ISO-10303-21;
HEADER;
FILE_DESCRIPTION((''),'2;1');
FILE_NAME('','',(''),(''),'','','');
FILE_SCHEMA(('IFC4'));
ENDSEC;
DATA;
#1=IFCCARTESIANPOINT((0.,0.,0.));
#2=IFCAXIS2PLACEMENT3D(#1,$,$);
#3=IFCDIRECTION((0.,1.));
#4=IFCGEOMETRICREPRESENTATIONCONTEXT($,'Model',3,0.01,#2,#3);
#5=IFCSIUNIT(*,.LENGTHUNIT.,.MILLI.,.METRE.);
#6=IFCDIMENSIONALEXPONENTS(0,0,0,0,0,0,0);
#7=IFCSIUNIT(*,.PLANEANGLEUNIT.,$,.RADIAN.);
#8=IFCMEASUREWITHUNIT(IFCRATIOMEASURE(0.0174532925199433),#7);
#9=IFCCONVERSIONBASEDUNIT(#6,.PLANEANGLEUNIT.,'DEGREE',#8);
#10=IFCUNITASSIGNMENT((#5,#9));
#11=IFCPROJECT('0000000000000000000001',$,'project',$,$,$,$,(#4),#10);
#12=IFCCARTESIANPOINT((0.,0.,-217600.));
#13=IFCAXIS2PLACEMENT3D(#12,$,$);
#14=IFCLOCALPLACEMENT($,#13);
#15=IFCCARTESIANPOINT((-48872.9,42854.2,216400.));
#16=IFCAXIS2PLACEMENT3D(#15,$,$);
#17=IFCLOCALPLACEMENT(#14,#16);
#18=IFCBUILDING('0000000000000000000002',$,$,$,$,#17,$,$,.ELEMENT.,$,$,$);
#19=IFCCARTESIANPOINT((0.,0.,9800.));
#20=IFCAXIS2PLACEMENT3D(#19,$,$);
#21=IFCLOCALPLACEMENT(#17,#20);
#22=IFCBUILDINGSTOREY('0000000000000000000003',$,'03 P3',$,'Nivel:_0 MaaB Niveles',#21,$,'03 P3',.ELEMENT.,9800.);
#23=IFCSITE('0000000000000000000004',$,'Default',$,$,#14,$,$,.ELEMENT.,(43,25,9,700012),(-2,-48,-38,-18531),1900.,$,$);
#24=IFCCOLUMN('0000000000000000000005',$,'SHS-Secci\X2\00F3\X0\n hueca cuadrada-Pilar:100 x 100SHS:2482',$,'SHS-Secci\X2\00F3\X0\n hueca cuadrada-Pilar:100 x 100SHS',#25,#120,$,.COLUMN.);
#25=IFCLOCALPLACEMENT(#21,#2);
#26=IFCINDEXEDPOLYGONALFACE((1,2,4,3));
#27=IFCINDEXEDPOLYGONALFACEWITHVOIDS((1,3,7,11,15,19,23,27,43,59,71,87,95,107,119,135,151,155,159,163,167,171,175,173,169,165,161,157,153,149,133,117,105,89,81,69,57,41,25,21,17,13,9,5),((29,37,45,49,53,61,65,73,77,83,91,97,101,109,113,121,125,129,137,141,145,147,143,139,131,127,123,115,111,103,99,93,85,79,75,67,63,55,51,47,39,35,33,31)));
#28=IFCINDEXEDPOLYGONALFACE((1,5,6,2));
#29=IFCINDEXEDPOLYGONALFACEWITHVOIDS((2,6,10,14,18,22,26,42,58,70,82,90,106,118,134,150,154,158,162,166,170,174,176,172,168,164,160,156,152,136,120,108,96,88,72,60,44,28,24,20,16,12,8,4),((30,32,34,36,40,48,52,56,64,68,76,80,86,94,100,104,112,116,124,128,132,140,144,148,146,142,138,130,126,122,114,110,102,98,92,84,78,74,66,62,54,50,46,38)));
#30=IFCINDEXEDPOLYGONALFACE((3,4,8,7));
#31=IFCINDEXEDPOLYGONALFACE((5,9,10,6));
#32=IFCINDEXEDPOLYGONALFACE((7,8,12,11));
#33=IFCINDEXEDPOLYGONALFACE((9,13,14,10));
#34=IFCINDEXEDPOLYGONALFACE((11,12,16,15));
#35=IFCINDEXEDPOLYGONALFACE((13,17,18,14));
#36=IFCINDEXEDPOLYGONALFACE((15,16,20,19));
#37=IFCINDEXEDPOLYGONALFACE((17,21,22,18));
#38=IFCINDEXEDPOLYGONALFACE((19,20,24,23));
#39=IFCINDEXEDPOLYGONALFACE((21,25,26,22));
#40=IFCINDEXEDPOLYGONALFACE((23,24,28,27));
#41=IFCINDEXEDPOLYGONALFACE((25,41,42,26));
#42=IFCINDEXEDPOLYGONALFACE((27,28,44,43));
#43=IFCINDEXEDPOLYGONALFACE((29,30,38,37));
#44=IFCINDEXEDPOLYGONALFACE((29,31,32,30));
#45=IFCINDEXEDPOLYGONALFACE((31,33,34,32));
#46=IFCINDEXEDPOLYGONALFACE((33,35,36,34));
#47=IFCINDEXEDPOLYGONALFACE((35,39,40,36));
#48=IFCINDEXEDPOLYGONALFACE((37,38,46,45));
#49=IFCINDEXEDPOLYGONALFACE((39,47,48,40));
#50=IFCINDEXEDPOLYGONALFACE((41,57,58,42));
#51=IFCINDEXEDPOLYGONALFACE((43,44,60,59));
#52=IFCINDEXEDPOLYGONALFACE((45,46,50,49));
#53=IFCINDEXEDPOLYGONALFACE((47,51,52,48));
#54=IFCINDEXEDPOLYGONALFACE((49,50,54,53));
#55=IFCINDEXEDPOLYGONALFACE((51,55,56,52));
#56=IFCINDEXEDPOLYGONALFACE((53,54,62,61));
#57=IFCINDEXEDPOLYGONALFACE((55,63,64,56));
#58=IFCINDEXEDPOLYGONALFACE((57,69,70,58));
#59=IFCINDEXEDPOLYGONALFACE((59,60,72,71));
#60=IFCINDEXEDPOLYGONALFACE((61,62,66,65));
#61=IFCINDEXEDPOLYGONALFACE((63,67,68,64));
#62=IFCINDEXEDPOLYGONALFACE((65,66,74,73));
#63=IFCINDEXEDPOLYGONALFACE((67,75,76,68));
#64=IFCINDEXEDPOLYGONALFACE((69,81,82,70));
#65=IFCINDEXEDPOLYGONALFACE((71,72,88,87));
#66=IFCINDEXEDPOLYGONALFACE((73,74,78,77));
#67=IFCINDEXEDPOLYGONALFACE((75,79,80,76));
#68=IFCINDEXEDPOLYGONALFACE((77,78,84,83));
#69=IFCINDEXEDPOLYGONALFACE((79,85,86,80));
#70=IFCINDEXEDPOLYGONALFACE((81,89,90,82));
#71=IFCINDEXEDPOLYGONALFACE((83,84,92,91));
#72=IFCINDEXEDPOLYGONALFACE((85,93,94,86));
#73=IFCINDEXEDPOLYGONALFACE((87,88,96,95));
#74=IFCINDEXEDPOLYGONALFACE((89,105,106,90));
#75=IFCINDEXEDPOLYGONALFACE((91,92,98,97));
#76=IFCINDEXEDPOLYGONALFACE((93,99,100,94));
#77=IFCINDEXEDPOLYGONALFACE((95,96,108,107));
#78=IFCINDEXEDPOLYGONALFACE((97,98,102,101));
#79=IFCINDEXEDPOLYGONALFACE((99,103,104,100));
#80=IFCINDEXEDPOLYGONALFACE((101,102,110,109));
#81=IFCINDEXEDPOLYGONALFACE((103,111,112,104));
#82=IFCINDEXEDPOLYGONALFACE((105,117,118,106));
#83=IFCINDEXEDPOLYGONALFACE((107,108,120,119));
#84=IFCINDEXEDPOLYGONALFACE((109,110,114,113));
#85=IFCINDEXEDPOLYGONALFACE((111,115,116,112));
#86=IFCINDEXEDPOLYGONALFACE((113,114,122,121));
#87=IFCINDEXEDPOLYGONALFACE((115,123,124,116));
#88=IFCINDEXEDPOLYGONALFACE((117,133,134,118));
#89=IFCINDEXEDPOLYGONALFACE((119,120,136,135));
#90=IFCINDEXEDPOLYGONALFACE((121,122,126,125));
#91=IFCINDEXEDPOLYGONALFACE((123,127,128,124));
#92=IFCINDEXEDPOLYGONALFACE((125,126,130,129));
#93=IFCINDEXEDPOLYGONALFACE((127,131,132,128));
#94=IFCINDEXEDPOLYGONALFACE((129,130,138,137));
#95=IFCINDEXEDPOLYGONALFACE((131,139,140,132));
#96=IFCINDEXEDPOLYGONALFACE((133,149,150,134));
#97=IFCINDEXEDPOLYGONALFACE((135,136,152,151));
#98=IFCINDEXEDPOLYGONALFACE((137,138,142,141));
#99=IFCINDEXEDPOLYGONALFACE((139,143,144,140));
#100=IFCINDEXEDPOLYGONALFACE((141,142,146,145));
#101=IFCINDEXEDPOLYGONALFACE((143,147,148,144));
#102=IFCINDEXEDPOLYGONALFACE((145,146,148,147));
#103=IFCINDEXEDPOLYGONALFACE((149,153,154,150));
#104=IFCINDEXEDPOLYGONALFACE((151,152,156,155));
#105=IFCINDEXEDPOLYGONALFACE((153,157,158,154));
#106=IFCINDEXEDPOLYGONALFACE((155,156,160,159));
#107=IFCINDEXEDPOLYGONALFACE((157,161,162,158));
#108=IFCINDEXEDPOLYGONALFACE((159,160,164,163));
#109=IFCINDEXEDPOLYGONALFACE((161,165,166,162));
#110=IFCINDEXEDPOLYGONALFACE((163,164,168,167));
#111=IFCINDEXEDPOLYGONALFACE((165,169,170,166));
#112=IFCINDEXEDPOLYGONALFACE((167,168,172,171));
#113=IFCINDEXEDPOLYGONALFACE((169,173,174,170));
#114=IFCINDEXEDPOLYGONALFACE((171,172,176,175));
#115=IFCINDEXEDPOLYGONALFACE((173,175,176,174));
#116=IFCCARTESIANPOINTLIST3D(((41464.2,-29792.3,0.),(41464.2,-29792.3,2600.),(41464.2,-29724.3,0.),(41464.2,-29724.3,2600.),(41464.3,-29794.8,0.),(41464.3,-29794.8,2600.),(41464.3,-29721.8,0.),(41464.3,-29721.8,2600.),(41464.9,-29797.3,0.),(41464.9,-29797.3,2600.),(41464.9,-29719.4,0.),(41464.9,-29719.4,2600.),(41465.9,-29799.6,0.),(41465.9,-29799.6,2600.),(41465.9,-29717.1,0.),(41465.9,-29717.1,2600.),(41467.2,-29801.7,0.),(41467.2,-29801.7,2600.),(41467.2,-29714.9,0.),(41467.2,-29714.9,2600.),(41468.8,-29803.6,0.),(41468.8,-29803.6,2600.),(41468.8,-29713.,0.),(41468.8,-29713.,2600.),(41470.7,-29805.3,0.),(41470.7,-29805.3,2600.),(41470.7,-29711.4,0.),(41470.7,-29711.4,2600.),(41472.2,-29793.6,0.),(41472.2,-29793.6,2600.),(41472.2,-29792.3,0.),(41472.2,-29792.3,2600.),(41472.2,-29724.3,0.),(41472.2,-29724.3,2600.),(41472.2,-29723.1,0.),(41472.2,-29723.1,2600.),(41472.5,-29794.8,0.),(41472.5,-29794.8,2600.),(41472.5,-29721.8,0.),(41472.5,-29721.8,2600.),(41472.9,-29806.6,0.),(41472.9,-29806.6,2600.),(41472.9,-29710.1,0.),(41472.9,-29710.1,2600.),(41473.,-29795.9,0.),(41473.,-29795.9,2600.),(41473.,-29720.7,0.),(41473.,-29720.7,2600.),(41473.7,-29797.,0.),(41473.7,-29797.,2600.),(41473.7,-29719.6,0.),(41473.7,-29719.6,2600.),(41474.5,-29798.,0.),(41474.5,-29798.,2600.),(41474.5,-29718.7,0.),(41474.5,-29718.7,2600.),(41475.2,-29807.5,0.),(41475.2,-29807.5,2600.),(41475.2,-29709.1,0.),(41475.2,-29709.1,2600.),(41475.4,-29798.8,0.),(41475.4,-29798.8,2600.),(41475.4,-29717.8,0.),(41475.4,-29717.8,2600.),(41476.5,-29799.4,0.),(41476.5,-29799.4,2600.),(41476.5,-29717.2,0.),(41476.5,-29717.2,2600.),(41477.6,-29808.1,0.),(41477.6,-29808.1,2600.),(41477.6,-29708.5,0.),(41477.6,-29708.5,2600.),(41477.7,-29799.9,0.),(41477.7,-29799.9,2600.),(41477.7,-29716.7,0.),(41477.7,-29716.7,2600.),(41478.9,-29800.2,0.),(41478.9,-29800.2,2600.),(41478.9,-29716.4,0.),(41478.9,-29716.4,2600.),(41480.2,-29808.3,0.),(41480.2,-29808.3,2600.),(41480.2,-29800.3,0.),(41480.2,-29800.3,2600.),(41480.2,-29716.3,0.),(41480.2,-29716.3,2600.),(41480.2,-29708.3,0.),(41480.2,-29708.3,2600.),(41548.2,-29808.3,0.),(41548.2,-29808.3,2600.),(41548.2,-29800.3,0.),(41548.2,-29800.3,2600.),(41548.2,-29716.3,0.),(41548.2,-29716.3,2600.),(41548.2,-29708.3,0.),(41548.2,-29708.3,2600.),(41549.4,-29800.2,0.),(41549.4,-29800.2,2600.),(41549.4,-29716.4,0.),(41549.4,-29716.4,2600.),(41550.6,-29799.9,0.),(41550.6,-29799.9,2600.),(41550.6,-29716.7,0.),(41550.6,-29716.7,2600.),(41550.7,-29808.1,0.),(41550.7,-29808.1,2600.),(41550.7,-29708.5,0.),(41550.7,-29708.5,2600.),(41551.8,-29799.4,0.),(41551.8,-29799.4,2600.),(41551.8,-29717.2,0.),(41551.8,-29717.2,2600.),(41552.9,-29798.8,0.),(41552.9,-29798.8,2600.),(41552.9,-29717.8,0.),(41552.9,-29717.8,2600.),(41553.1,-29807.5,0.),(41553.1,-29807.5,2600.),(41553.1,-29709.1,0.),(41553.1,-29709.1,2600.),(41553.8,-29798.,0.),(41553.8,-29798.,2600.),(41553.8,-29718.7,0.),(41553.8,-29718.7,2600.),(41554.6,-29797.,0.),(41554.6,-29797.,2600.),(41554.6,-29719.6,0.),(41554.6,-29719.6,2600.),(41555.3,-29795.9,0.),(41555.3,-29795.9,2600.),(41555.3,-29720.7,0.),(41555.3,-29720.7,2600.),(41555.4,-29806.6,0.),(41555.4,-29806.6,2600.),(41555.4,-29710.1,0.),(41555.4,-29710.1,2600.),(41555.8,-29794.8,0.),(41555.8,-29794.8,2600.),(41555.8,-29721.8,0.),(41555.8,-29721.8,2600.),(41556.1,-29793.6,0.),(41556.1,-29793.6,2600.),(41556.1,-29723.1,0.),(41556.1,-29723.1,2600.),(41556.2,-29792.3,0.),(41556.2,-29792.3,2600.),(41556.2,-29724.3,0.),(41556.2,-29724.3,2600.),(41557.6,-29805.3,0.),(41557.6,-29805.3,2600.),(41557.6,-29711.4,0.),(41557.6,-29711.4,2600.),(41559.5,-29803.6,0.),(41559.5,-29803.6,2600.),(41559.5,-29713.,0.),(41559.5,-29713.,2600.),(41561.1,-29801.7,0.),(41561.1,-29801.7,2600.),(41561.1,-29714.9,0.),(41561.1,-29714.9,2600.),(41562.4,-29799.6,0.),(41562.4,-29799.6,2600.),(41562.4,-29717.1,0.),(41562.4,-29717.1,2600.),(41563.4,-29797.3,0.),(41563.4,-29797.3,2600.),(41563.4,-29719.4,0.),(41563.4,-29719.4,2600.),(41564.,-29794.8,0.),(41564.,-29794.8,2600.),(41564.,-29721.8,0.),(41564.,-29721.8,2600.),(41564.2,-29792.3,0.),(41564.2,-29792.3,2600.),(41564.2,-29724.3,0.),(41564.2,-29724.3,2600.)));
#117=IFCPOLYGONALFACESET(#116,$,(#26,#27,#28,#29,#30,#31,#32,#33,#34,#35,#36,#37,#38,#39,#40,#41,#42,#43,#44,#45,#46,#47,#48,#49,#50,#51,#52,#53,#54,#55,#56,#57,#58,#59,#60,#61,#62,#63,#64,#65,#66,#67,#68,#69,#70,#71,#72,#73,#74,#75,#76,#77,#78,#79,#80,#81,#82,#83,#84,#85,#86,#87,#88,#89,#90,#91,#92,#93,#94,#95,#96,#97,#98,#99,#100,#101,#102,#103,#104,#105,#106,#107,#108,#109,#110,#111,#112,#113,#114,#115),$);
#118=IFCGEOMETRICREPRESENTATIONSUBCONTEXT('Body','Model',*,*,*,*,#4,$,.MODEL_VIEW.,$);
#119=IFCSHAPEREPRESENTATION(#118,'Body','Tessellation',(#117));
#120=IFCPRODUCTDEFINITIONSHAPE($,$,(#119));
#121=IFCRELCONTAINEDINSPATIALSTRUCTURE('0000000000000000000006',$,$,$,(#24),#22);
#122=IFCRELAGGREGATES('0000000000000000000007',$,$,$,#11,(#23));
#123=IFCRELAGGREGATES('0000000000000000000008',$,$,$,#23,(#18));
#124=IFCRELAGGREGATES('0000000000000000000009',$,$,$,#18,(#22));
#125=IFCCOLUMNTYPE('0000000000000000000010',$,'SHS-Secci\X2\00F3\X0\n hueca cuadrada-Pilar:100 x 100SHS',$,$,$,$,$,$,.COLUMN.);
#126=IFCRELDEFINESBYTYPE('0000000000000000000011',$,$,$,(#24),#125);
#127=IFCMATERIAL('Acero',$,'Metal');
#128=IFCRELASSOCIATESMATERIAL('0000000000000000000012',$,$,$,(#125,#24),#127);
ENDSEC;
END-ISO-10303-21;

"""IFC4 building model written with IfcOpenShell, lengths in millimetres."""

from ifc_helpers import new_model, entity, si_unit, converted_unit, direction, frame, origin, place, context, subcontext, project, spatial, indexed_curve, outline, extrude, source, transform, mapped, material, type_object, type_shapes, element, save


model = new_model("IFC4")

# Units and contexts
model_context = context("Model", 3, precision=0.01, world=origin(), true_north=direction((0.0, 1.0)))
body_context = subcontext(model_context, "Body", "Model", "MODEL_VIEW")
ifc_project = project(units=[si_unit("LENGTHUNIT", "METRE", prefix="MILLI"), converted_unit("PLANEANGLEUNIT", "DEGREE", entity("IfcRatioMeasure", 0.0174532925199433), si_unit("PLANEANGLEUNIT", "RADIAN"), dimensions=[0, 0, 0, 0, 0, 0, 0])], contexts=[model_context])

# Site, building, storey
site_placement = place(None, frame((0.0, 0.0, -217600.0)))
site = spatial("IfcSite", under=ifc_project, at=site_placement, Name="Default", CompositionType="ELEMENT", RefLatitude=(43, 25, 9, 700012), RefLongitude=(-2, -48, -38, -18531), RefElevation=1900.0)
building_placement = place(site_placement, frame((-48872.9, 42854.2, 216400.0)))
building = spatial("IfcBuilding", under=site, at=building_placement, CompositionType="ELEMENT")
storey_placement = place(building_placement, frame((0.0, 0.0, 9800.0)))
storey = spatial("IfcBuildingStorey", under=building, at=storey_placement, Name="03 P3", ObjectType="Nivel:_0 MaaB Niveles", LongName="03 P3", CompositionType="ELEMENT", Elevation=9800.0)

# Column
ifc_material_1 = material(Name="Acero", Category="Metal")
column_type_1 = type_object("IfcColumnType", Name="SHS-Sección hueca cuadrada-Pilar:100 x 100SHS", PredefinedType="COLUMN", material=ifc_material_1)
shared_shape_1 = source(origin(), body_context, "Body", "SweptSolid", [
    extrude(outline(indexed_curve([(-34.0, -50.0), (34.0, -50.0), (36.5, -49.8), (38.9, -49.2), (41.3, -48.3), (43.4, -46.9), (45.3, -45.3), (46.9, -43.4), (48.3, -41.3), (49.2, -38.9), (49.8, -36.5), (50.0, -34.0), (50.0, 34.0), (49.8, 36.5), (49.2, 38.9), (48.3, 41.3), (46.9, 43.4), (45.3, 45.3), (43.4, 46.9), (41.3, 48.3), (38.9, 49.2), (36.5, 49.8), (34.0, 50.0), (-34.0, 50.0), (-36.5, 49.8), (-38.9, 49.2), (-41.3, 48.3), (-43.4, 46.9), (-45.3, 45.3), (-46.9, 43.4), (-48.3, 41.3), (-49.2, 38.9), (-49.8, 36.5), (-50.0, 34.0), (-50.0, -34.0), (-49.8, -36.5), (-49.2, -38.9), (-48.3, -41.3), (-46.9, -43.4), (-45.3, -45.3), (-43.4, -46.9), (-41.3, -48.3), (-38.9, -49.2), (-36.5, -49.8), (-34.0, -50.0)], self_intersect=False), holes=[indexed_curve([(-42.0, 34.0), (-41.9, 35.3), (-41.6, 36.5), (-41.1, 37.6), (-40.5, 38.7), (-39.7, 39.7), (-38.7, 40.5), (-37.6, 41.1), (-36.5, 41.6), (-35.3, 41.9), (-34.0, 42.0), (34.0, 42.0), (35.3, 41.9), (36.5, 41.6), (37.6, 41.1), (38.7, 40.5), (39.7, 39.7), (40.5, 38.7), (41.1, 37.6), (41.6, 36.5), (41.9, 35.3), (42.0, 34.0), (42.0, -34.0), (41.9, -35.3), (41.6, -36.5), (41.1, -37.6), (40.5, -38.7), (39.7, -39.7), (38.7, -40.5), (37.6, -41.1), (36.5, -41.6), (35.3, -41.9), (34.0, -42.0), (-34.0, -42.0), (-35.3, -41.9), (-36.5, -41.6), (-37.6, -41.1), (-38.7, -40.5), (-39.7, -39.7), (-40.5, -38.7), (-41.1, -37.6), (-41.6, -36.5), (-41.9, -35.3), (-42.0, -34.0), (-42.0, 34.0)], self_intersect=False)]), frame((0.0, 0.0, 9800.0), z_axis=(0.0, 0.0, 1.0), x_axis=(0.0, 1.0, 0.0)), (0.0, 0.0, 1.0), 2600.0),
])
type_shapes(column_type_1, [shared_shape_1])
column_1_placement = place(storey_placement, frame((41514.2, -29758.3, -9800.0), z_axis=(0.0, 0.0, 1.0), x_axis=(0.0, -1.0, 0.0)))
element("IfcColumn", 1, at=column_1_placement, inside=storey, type_object=column_type_1, material=ifc_material_1, Name="SHS-Sección hueca cuadrada-Pilar:100 x 100SHS:2482", ObjectType="SHS-Sección hueca cuadrada-Pilar:100 x 100SHS", PredefinedType="COLUMN", context=body_context, shape_type="MappedRepresentation", body=[
    mapped(shared_shape_1, transform((0.0, 0.0, 0.0), scale=1.0)),
])

save(model, "model.ifc")
